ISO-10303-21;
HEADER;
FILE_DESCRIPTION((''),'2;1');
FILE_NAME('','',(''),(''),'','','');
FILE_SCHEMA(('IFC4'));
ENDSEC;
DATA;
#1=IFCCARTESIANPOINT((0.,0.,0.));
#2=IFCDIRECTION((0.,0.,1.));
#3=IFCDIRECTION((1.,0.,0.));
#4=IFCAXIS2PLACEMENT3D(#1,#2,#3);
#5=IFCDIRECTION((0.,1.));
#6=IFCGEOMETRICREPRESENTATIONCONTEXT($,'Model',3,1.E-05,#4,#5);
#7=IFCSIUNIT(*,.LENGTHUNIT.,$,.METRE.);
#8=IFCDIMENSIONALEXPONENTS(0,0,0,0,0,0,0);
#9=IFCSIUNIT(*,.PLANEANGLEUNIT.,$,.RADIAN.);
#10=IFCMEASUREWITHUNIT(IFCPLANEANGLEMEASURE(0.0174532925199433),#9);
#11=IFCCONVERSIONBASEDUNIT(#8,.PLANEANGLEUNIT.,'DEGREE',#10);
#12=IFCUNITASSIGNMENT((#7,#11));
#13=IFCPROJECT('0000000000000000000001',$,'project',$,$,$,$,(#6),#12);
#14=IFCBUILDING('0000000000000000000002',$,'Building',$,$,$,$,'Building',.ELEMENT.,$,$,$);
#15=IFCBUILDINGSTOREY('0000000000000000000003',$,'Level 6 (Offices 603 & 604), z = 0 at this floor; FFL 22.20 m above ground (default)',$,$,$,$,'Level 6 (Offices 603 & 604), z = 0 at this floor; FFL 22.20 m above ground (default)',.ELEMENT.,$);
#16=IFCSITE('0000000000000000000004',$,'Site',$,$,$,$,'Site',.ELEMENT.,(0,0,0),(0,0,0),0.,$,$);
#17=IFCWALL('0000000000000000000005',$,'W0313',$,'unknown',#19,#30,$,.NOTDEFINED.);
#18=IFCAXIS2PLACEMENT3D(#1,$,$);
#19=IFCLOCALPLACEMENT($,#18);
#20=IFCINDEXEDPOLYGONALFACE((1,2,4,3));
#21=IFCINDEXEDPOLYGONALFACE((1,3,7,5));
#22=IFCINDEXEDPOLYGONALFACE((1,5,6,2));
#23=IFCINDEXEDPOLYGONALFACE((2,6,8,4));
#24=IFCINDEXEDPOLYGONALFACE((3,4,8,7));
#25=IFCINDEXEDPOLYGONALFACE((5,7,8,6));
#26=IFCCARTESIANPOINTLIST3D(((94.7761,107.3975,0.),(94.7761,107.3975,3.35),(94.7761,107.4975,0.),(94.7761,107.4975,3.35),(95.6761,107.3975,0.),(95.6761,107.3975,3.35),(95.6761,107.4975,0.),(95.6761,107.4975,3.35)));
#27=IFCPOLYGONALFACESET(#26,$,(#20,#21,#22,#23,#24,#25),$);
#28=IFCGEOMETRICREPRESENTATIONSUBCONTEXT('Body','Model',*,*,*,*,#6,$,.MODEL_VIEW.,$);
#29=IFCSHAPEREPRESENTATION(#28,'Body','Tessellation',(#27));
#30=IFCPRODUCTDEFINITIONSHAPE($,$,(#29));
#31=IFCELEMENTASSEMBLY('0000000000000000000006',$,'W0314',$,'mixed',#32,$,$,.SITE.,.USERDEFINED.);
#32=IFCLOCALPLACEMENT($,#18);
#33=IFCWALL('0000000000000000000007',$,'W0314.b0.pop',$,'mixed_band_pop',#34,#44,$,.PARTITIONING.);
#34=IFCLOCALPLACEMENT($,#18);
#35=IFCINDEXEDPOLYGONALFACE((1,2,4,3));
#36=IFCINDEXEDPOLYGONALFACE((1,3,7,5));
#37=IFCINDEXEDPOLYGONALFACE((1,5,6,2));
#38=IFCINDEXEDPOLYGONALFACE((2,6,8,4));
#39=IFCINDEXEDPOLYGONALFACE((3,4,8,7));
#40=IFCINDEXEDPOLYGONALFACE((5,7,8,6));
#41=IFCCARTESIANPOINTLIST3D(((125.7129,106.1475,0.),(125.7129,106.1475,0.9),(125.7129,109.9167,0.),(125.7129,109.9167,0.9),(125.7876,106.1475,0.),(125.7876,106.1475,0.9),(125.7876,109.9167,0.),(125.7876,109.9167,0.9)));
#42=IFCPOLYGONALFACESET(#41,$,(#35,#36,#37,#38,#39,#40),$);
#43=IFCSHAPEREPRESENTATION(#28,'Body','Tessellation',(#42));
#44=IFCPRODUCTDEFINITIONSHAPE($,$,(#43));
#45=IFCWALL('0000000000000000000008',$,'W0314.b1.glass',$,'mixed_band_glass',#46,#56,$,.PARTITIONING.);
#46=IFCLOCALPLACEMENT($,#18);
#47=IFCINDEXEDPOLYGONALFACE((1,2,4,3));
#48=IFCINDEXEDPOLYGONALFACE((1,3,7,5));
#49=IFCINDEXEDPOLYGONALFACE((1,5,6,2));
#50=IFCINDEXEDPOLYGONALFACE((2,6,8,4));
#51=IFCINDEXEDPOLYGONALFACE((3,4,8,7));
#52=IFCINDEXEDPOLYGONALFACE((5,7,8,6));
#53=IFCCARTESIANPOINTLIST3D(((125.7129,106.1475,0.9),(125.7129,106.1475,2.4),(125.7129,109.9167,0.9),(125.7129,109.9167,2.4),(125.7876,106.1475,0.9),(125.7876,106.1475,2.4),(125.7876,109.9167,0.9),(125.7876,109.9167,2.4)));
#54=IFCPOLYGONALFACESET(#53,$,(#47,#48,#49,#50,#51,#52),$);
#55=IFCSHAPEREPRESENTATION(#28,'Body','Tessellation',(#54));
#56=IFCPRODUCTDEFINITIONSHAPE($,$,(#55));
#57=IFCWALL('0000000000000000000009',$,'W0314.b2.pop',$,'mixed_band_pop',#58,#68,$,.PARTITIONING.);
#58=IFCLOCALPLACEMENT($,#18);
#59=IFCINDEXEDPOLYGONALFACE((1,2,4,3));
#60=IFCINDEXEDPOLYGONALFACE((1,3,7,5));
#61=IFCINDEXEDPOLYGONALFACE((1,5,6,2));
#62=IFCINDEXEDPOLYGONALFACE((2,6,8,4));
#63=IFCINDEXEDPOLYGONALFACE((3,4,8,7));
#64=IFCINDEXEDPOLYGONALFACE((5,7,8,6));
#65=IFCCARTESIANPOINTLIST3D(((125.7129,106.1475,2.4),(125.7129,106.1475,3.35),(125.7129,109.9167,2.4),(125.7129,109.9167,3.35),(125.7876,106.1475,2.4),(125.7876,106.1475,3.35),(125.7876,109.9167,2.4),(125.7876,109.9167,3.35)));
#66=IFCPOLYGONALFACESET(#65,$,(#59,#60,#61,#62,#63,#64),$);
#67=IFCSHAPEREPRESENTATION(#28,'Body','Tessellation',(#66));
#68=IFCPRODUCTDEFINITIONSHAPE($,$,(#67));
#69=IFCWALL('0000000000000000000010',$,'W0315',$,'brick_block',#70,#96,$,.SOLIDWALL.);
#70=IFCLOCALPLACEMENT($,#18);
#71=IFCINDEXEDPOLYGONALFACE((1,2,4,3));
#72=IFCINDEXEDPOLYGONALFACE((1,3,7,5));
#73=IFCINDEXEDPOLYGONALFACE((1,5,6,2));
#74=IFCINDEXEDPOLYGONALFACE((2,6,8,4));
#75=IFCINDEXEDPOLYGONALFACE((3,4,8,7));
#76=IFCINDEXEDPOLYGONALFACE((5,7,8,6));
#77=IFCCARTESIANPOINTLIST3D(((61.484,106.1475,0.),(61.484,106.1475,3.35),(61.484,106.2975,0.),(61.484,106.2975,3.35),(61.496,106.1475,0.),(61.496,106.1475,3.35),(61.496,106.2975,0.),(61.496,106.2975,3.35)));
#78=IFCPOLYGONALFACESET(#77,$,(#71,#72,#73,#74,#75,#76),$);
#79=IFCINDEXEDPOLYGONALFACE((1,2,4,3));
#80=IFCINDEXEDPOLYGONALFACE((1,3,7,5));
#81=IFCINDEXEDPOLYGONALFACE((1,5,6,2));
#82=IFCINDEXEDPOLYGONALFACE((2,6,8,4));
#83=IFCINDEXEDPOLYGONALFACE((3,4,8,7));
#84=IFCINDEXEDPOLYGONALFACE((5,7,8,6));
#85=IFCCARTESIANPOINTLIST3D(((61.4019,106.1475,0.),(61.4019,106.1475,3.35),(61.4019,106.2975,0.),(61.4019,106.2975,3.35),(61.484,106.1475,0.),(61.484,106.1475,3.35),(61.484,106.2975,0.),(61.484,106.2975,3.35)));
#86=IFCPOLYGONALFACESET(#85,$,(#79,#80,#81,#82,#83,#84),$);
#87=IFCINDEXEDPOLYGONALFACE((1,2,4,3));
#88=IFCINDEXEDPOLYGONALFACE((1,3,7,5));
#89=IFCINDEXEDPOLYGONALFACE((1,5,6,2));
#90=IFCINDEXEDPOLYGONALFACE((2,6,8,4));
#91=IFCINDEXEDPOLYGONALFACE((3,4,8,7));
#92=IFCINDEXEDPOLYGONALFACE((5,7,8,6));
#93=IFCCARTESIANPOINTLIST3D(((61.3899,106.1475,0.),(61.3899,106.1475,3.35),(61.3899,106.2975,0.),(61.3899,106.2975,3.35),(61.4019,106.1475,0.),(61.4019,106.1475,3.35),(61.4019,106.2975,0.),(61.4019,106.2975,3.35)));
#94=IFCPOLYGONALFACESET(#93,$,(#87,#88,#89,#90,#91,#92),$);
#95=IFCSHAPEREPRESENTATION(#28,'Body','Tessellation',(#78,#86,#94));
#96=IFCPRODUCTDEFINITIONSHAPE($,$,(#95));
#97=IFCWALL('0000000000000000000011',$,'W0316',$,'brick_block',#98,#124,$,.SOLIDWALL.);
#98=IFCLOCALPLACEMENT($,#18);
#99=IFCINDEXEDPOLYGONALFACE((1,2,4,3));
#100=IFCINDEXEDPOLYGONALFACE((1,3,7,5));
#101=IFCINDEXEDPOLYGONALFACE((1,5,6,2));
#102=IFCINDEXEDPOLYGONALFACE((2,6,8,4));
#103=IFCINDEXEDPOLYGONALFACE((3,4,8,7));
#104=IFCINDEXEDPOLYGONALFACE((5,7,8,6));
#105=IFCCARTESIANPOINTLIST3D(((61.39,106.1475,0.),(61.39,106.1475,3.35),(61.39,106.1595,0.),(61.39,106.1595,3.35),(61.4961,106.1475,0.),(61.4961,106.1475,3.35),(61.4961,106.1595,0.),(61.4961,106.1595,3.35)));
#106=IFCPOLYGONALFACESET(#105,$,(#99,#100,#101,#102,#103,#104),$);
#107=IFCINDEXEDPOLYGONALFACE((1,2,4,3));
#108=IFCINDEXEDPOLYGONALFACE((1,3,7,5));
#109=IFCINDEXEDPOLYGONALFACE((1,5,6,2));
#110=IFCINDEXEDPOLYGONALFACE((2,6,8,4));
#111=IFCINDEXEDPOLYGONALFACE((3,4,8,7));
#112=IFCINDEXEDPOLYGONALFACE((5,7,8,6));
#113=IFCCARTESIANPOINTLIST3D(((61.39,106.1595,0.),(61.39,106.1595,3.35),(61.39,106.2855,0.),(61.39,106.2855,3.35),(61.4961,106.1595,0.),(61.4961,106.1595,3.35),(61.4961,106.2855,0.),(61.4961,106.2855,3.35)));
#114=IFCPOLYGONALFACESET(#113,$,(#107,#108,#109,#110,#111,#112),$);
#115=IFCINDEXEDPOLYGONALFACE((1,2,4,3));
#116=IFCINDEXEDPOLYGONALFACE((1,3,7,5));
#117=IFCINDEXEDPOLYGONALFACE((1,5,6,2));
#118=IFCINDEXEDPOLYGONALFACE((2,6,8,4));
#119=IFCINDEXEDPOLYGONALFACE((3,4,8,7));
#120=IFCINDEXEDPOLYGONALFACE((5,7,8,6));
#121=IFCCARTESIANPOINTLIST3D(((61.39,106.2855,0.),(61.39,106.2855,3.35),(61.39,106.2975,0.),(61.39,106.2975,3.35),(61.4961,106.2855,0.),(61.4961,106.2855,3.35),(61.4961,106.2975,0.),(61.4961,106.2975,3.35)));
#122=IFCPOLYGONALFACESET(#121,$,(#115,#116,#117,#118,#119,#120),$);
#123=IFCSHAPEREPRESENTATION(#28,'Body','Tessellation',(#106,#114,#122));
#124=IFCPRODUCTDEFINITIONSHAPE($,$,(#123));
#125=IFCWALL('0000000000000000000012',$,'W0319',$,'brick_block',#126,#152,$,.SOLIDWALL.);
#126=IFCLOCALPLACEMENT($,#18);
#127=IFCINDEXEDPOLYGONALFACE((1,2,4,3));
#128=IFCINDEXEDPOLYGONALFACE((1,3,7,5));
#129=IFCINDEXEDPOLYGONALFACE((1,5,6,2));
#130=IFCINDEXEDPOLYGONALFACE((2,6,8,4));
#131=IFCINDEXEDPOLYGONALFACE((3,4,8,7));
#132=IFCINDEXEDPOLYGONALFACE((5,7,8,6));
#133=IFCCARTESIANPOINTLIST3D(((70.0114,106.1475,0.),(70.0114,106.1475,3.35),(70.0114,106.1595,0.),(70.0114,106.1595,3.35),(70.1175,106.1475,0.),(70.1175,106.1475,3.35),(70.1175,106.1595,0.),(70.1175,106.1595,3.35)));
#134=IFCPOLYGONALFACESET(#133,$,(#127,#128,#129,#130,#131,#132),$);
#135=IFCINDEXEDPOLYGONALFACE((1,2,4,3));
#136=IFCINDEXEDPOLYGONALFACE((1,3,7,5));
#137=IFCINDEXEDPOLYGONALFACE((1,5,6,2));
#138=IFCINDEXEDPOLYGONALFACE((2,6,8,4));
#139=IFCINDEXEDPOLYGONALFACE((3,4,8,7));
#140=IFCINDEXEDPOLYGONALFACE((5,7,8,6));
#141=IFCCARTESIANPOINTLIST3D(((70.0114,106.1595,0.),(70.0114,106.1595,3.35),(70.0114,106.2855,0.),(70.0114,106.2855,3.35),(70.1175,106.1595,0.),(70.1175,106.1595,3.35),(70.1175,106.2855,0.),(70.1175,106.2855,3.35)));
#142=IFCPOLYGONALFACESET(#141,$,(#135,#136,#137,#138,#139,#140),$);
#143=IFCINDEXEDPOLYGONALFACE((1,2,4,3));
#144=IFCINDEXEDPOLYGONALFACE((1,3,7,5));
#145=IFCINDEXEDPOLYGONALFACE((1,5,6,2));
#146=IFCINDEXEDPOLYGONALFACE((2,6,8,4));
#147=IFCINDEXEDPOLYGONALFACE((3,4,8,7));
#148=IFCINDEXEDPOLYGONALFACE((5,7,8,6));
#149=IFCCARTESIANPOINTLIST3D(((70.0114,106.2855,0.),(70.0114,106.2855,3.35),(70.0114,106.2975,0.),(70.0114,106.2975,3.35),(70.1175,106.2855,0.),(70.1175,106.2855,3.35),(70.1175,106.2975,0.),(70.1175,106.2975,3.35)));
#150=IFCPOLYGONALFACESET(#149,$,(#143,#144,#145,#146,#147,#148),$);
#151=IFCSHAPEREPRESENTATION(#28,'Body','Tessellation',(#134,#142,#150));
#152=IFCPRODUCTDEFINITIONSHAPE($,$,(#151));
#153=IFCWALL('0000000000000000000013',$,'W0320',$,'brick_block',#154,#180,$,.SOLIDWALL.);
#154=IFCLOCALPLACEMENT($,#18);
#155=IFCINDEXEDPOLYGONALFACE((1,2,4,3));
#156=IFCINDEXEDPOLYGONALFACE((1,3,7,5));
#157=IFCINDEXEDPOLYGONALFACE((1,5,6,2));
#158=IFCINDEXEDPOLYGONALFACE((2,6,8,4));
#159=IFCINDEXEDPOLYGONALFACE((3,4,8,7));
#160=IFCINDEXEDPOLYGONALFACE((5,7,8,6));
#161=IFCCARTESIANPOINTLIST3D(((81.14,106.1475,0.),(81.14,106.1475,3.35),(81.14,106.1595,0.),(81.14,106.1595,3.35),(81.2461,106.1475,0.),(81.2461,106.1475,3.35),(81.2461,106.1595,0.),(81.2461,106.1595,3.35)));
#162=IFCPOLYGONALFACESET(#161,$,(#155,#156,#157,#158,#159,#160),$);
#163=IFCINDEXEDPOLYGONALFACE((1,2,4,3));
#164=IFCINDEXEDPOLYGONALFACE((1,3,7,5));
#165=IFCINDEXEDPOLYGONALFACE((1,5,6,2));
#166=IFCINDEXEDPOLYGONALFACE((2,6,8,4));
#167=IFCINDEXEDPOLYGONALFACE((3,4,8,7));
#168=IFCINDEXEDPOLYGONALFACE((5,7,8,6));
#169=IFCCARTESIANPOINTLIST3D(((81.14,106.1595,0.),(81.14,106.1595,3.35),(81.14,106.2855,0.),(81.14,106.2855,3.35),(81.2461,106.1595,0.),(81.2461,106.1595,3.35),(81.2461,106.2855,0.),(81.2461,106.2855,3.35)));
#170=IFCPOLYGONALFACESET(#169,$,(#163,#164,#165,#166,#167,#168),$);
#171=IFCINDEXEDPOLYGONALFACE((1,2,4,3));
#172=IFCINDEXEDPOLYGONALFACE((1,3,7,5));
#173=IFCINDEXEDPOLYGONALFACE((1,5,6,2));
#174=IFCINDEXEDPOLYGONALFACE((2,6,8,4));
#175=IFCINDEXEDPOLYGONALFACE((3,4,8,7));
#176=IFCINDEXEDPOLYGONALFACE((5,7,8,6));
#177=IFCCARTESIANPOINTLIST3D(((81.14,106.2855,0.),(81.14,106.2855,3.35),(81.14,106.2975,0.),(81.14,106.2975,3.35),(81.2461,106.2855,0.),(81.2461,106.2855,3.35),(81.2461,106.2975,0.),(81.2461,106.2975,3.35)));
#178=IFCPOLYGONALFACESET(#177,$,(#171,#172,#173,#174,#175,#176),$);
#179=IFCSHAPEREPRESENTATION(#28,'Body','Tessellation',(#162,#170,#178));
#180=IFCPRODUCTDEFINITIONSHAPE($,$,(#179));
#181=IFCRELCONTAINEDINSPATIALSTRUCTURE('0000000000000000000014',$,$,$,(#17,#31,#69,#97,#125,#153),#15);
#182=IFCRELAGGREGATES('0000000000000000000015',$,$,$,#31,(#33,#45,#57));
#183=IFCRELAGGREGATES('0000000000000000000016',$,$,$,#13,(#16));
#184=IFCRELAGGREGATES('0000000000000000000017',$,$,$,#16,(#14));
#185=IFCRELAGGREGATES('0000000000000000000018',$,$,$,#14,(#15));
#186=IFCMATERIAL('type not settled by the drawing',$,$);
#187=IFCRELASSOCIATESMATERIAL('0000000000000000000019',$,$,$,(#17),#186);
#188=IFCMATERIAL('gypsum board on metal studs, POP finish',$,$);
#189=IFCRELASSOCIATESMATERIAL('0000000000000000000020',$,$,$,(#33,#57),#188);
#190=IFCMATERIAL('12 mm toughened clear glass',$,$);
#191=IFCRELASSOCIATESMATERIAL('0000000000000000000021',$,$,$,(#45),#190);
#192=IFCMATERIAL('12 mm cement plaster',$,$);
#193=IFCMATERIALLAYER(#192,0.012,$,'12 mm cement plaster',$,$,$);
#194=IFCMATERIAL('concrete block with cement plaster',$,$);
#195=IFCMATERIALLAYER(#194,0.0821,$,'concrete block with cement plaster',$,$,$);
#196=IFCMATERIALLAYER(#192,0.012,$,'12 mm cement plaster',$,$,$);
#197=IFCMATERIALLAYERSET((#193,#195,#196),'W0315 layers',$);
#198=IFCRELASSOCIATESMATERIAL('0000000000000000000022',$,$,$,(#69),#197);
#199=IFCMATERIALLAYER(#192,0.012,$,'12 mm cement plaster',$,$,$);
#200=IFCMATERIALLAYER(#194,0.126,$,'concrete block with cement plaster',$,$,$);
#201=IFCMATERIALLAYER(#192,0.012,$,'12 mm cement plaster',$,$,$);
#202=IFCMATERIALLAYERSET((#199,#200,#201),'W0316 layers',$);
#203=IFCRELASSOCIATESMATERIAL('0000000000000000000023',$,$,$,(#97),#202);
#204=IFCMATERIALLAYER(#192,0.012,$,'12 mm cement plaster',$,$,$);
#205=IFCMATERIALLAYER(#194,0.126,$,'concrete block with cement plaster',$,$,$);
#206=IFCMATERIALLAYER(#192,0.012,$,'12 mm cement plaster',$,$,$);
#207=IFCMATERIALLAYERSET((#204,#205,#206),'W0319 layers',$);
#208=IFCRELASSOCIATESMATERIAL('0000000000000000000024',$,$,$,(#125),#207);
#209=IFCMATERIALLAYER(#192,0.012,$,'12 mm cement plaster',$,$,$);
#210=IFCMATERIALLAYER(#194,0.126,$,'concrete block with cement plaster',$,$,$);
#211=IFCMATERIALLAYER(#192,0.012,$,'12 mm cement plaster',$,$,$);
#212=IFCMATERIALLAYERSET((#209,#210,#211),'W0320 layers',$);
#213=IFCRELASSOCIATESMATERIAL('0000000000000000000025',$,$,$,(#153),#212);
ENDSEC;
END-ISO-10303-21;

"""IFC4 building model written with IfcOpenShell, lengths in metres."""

from ifc_helpers import new_model, entity, si_unit, converted_unit, direction, frame, frame_2d, origin_with_axes, origin_2d_with_axis, place, context, subcontext, project, spatial, rectangle, extrude, material, layer, layer_set, layer_usage, element, aggregate, save


model = new_model("IFC4")

# Units and contexts
model_context = context("Model", 3, precision=1e-05, world=origin_with_axes(), true_north=direction((0.0, 1.0)))
body_context = subcontext(model_context, "Body", "Model", "MODEL_VIEW")
ifc_project = project(units=[si_unit("LENGTHUNIT", "METRE"), converted_unit("PLANEANGLEUNIT", "DEGREE", entity("IfcPlaneAngleMeasure", 0.0174532925199433), si_unit("PLANEANGLEUNIT", "RADIAN"), dimensions=[0, 0, 0, 0, 0, 0, 0])], contexts=[model_context])

# Site, building, storey
site = spatial("IfcSite", under=ifc_project, Name="Site", LongName="Site", CompositionType="ELEMENT", RefLatitude=(0, 0, 0), RefLongitude=(0, 0, 0), RefElevation=0.0)
building = spatial("IfcBuilding", under=site, Name="Building", LongName="Building", CompositionType="ELEMENT")
storey = spatial("IfcBuildingStorey", under=building, Name="Level 6 (Offices 603 & 604), z = 0 at this floor; FFL 22.20 m above ground (default)", LongName="Level 6 (Offices 603 & 604), z = 0 at this floor; FFL 22.20 m above ground (default)", CompositionType="ELEMENT")

# Wall
ifc_material_1 = material(Name="type not settled by the drawing")
placement = place(None, origin_with_axes())
element("IfcWall", 1, at=placement, inside=storey, material=ifc_material_1, Name="W0313", ObjectType="unknown", PredefinedType="NOTDEFINED", context=body_context, shape_type="SweptSolid", body=[
    extrude(rectangle(XDim=0.9, YDim=0.1, at=frame_2d((0.0, 0.0), x_axis=(1.0, 0.0))), frame((95.2261, 107.4475, 0.0), z_axis=(0.0, 0.0, 1.0), x_axis=(1.0, 0.0, 0.0)), (0.0, 0.0, 1.0), 3.35),
])

# Element assembly, walls
assembly_1 = element("IfcElementAssembly", 2, inside=storey, Name="W0314", ObjectType="mixed", AssemblyPlace="SITE", PredefinedType="USERDEFINED")
ifc_material_2 = material(Name="gypsum board on metal studs, POP finish")
wall_1 = element("IfcWall", 3, at=placement, material=ifc_material_2, Name="W0314.b0.pop", ObjectType="mixed_band_pop", PredefinedType="PARTITIONING", context=body_context, shape_type="SweptSolid", body=[
    extrude(rectangle(XDim=3.7692, YDim=0.0747, at=frame_2d((0.0, 0.0), x_axis=(0.0, 1.0))), frame((125.7503, 108.0321, 0.0), z_axis=(0.0, 0.0, 1.0), x_axis=(1.0, 0.0, 0.0)), (0.0, 0.0, 1.0), 0.9),
])
ifc_material_3 = material(Name="12 mm toughened clear glass")
wall_2 = element("IfcWall", 4, at=placement, material=ifc_material_3, Name="W0314.b1.glass", ObjectType="mixed_band_glass", PredefinedType="PARTITIONING", context=body_context, shape_type="SweptSolid", body=[
    extrude(rectangle(XDim=3.7692, YDim=0.0747, at=frame_2d((0.0, 0.0), x_axis=(0.0, 1.0))), frame((125.7503, 108.0321, 0.9), z_axis=(0.0, 0.0, 1.0), x_axis=(1.0, 0.0, 0.0)), (0.0, 0.0, 1.0), 1.5),
])
wall_3 = element("IfcWall", 5, at=placement, material=ifc_material_2, Name="W0314.b2.pop", ObjectType="mixed_band_pop", PredefinedType="PARTITIONING", context=body_context, shape_type="SweptSolid", body=[
    extrude(rectangle(XDim=3.7692, YDim=0.0747, at=frame_2d((0.0, 0.0), x_axis=(0.0, 1.0))), frame((125.7503, 108.0321, 2.4), z_axis=(0.0, 0.0, 1.0), x_axis=(1.0, 0.0, 0.0)), (0.0, 0.0, 1.0), 0.95),
])
aggregate(assembly_1, [wall_1, wall_2, wall_3])

# Walls
ifc_material_4 = material(Name="12 mm cement plaster")
ifc_layer_1 = layer(ifc_material_4, 0.012, Name="12 mm cement plaster")
ifc_material_5 = material(Name="concrete block with cement plaster")
ifc_layer_2 = layer(ifc_material_5, 0.0821, Name="concrete block with cement plaster")
ifc_layer_3 = layer(ifc_material_4, 0.012, Name="12 mm cement plaster")
ifc_layer_set_1 = layer_set([ifc_layer_1, ifc_layer_2, ifc_layer_3], Name="W0315 layers")
ifc_layer_usage_1 = layer_usage(ifc_layer_set_1, "AXIS2", "POSITIVE", -0.053)
element("IfcWall", 6, at=placement, inside=storey, material=ifc_layer_usage_1, Name="W0315", ObjectType="brick_block", PredefinedType="SOLIDWALL", context=body_context, shape_type="SweptSolid", body=[
    extrude(rectangle(XDim=0.15, YDim=0.012, at=frame_2d((0.0, 0.0), x_axis=(0.0, 1.0))), frame((61.49, 106.2225, 0.0), z_axis=(0.0, 0.0, 1.0), x_axis=(1.0, 0.0, 0.0)), (0.0, 0.0, 1.0), 3.35),
    extrude(rectangle(XDim=0.15, YDim=0.0821, at=frame_2d((-0.0471, 0.0), x_axis=(0.0, 1.0))), frame((61.49, 106.2225, 0.0), z_axis=(0.0, 0.0, 1.0), x_axis=(1.0, 0.0, 0.0)), (0.0, 0.0, 1.0), 3.35),
    extrude(rectangle(XDim=0.15, YDim=0.012, at=frame_2d((-0.0941, 0.0), x_axis=(0.0, 1.0))), frame((61.49, 106.2225, 0.0), z_axis=(0.0, 0.0, 1.0), x_axis=(1.0, 0.0, 0.0)), (0.0, 0.0, 1.0), 3.35),
])
ifc_layer_4 = layer(ifc_material_4, 0.012, Name="12 mm cement plaster")
ifc_layer_5 = layer(ifc_material_5, 0.126, Name="concrete block with cement plaster")
ifc_layer_6 = layer(ifc_material_4, 0.012, Name="12 mm cement plaster")
ifc_layer_set_2 = layer_set([ifc_layer_4, ifc_layer_5, ifc_layer_6], Name="W0316 layers")
ifc_layer_usage_2 = layer_usage(ifc_layer_set_2, "AXIS2", "POSITIVE", -0.075)
element("IfcWall", 7, at=placement, inside=storey, material=ifc_layer_usage_2, Name="W0316", ObjectType="brick_block", PredefinedType="SOLIDWALL", context=body_context, shape_type="SweptSolid", body=[
    extrude(rectangle(XDim=0.1061, YDim=0.012, at=frame_2d((0.0, 0.0), x_axis=(1.0, 0.0))), frame((61.443, 106.1535, 0.0), z_axis=(0.0, 0.0, 1.0), x_axis=(1.0, 0.0, 0.0)), (0.0, 0.0, 1.0), 3.35),
    extrude(rectangle(XDim=0.1061, YDim=0.126, at=frame_2d((0.0, 0.069), x_axis=(1.0, 0.0))), frame((61.443, 106.1535, 0.0), z_axis=(0.0, 0.0, 1.0), x_axis=(1.0, 0.0, 0.0)), (0.0, 0.0, 1.0), 3.35),
    extrude(rectangle(XDim=0.1061, YDim=0.012, at=frame_2d((0.0, 0.138), x_axis=(1.0, 0.0))), frame((61.443, 106.1535, 0.0), z_axis=(0.0, 0.0, 1.0), x_axis=(1.0, 0.0, 0.0)), (0.0, 0.0, 1.0), 3.35),
])
ifc_layer_7 = layer(ifc_material_4, 0.012, Name="12 mm cement plaster")
ifc_layer_8 = layer(ifc_material_5, 0.126, Name="concrete block with cement plaster")
ifc_layer_9 = layer(ifc_material_4, 0.012, Name="12 mm cement plaster")
ifc_layer_set_3 = layer_set([ifc_layer_7, ifc_layer_8, ifc_layer_9], Name="W0319 layers")
ifc_layer_usage_3 = layer_usage(ifc_layer_set_3, "AXIS2", "POSITIVE", -0.075)
element("IfcWall", 8, at=placement, inside=storey, material=ifc_layer_usage_3, Name="W0319", ObjectType="brick_block", PredefinedType="SOLIDWALL", context=body_context, shape_type="SweptSolid", body=[
    extrude(rectangle(XDim=0.1061, YDim=0.012, at=origin_2d_with_axis()), frame((70.0644, 106.1535, 0.0), z_axis=(0.0, 0.0, 1.0), x_axis=(1.0, 0.0, 0.0)), (0.0, 0.0, 1.0), 3.35),
    extrude(rectangle(XDim=0.1061, YDim=0.126, at=frame_2d((0.0, 0.069), x_axis=(1.0, 0.0))), frame((70.0644, 106.1535, 0.0), z_axis=(0.0, 0.0, 1.0), x_axis=(1.0, 0.0, 0.0)), (0.0, 0.0, 1.0), 3.35),
    extrude(rectangle(XDim=0.1061, YDim=0.012, at=frame_2d((0.0, 0.138), x_axis=(1.0, 0.0))), frame((70.0644, 106.1535, 0.0), z_axis=(0.0, 0.0, 1.0), x_axis=(1.0, 0.0, 0.0)), (0.0, 0.0, 1.0), 3.35),
])
ifc_layer_10 = layer(ifc_material_4, 0.012, Name="12 mm cement plaster")
ifc_layer_11 = layer(ifc_material_5, 0.126, Name="concrete block with cement plaster")
ifc_layer_12 = layer(ifc_material_4, 0.012, Name="12 mm cement plaster")
ifc_layer_set_4 = layer_set([ifc_layer_10, ifc_layer_11, ifc_layer_12], Name="W0320 layers")
ifc_layer_usage_4 = layer_usage(ifc_layer_set_4, "AXIS2", "POSITIVE", -0.075)
element("IfcWall", 9, at=placement, inside=storey, material=ifc_layer_usage_4, Name="W0320", ObjectType="brick_block", PredefinedType="SOLIDWALL", context=body_context, shape_type="SweptSolid", body=[
    extrude(rectangle(XDim=0.1061, YDim=0.012, at=origin_2d_with_axis()), frame((81.193, 106.1535, 0.0), z_axis=(0.0, 0.0, 1.0), x_axis=(1.0, 0.0, 0.0)), (0.0, 0.0, 1.0), 3.35),
    extrude(rectangle(XDim=0.1061, YDim=0.126, at=frame_2d((0.0, 0.069), x_axis=(1.0, 0.0))), frame((81.193, 106.1535, 0.0), z_axis=(0.0, 0.0, 1.0), x_axis=(1.0, 0.0, 0.0)), (0.0, 0.0, 1.0), 3.35),
    extrude(rectangle(XDim=0.1061, YDim=0.012, at=frame_2d((0.0, 0.138), x_axis=(1.0, 0.0))), frame((81.193, 106.1535, 0.0), z_axis=(0.0, 0.0, 1.0), x_axis=(1.0, 0.0, 0.0)), (0.0, 0.0, 1.0), 3.35),
])

save(model, "model.ifc")
